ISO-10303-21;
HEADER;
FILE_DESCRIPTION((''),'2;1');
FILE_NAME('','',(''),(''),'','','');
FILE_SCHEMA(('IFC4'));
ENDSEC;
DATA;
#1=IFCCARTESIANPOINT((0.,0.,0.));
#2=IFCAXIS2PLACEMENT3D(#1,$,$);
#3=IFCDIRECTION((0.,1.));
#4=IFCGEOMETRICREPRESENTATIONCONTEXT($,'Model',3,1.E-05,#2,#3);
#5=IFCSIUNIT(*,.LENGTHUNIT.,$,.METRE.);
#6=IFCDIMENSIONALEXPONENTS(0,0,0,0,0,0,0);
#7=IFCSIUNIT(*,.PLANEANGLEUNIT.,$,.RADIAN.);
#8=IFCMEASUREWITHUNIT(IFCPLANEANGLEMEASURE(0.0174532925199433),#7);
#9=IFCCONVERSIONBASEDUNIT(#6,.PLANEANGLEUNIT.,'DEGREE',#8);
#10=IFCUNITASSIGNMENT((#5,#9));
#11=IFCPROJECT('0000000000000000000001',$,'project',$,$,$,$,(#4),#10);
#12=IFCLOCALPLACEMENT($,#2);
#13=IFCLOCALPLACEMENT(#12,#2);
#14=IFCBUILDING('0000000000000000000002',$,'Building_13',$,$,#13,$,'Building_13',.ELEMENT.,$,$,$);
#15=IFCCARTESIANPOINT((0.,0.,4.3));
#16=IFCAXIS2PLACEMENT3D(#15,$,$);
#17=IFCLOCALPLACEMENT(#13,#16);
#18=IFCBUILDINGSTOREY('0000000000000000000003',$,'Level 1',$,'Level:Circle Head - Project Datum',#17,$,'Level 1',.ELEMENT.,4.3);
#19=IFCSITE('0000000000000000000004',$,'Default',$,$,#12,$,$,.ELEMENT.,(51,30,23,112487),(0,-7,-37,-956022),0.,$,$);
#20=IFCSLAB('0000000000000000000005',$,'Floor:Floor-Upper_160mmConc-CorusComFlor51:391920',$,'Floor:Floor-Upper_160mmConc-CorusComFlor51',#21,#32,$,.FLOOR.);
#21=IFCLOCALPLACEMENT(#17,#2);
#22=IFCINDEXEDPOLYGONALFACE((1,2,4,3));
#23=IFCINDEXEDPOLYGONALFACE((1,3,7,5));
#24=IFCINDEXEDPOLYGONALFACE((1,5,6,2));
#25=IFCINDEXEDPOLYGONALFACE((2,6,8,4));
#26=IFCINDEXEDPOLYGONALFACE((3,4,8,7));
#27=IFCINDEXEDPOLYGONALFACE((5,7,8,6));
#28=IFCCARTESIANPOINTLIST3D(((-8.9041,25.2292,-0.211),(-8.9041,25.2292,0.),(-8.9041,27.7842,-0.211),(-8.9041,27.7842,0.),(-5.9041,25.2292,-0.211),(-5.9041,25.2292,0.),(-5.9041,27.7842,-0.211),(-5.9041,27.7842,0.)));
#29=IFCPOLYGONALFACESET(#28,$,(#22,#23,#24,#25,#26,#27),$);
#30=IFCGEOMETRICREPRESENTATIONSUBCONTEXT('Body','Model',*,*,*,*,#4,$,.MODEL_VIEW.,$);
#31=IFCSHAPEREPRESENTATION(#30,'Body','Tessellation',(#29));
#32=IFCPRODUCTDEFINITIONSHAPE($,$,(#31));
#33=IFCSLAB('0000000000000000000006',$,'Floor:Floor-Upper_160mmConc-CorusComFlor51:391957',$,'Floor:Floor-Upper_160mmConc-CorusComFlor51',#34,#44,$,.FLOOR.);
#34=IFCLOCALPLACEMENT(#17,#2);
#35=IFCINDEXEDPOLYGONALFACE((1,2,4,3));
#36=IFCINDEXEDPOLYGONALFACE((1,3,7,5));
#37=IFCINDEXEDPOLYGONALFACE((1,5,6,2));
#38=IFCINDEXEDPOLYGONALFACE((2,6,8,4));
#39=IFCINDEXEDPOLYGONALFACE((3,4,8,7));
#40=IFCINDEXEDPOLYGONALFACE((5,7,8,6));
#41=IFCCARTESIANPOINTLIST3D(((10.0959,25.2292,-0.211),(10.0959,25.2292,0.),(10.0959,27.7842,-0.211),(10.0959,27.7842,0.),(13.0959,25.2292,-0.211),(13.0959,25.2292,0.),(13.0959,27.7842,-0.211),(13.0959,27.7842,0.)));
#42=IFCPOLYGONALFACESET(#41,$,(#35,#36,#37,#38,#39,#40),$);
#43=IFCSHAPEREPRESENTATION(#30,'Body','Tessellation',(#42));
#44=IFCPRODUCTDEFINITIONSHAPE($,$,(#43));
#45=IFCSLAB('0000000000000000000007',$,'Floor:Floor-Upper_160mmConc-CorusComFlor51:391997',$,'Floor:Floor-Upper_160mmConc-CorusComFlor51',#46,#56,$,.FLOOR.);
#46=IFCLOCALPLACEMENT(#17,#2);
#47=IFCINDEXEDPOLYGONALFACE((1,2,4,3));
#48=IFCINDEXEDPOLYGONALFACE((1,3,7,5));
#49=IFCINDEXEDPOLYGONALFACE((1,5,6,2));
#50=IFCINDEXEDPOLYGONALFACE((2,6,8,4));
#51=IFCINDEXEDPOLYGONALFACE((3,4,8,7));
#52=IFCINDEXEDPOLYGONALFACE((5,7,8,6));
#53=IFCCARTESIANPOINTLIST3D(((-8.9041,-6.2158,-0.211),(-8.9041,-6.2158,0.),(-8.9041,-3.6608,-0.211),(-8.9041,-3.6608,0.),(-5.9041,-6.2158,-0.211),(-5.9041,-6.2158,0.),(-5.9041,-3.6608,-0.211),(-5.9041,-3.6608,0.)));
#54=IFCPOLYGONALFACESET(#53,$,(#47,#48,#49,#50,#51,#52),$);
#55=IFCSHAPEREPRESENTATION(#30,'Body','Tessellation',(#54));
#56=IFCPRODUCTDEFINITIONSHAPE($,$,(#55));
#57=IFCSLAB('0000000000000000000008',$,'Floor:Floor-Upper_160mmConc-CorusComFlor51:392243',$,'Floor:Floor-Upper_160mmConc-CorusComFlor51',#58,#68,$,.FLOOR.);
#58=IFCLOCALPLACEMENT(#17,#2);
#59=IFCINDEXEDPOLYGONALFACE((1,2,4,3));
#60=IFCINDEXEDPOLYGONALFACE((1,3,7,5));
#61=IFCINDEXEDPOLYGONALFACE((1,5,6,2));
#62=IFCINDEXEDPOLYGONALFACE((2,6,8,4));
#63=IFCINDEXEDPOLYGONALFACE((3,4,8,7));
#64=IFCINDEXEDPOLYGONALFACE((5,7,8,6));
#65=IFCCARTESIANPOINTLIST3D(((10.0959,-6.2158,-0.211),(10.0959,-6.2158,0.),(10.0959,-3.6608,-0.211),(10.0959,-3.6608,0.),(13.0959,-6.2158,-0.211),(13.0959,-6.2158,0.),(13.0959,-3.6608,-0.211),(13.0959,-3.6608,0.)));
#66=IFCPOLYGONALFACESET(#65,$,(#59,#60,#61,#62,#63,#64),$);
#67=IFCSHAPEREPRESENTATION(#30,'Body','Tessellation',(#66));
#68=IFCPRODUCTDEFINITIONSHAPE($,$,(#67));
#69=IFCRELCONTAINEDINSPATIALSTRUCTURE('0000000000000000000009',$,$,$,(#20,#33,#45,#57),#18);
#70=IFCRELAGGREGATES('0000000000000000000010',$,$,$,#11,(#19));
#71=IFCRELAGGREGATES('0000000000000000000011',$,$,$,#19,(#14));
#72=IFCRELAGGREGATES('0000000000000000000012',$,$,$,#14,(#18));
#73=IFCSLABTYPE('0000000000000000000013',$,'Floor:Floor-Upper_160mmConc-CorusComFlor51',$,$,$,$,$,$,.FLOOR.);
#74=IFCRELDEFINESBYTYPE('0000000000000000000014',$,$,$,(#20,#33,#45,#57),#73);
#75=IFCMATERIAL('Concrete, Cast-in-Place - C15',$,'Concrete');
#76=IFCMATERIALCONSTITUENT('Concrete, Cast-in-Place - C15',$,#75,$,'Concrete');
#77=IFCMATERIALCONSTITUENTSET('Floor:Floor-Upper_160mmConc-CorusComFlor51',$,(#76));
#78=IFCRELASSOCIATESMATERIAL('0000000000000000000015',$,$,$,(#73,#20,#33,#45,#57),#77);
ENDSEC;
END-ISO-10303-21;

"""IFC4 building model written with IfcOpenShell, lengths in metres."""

from ifc_helpers import new_model, entity, si_unit, converted_unit, direction, frame, origin, place, context, subcontext, project, spatial, indexed_curve, outline, extrude, material, constituent, constituent_set, type_object, element, save


model = new_model("IFC4")

# Units and contexts
model_context = context("Model", 3, precision=1e-05, world=origin(), true_north=direction((0.0, 1.0)))
body_context = subcontext(model_context, "Body", "Model", "MODEL_VIEW")
ifc_project = project(units=[si_unit("LENGTHUNIT", "METRE"), converted_unit("PLANEANGLEUNIT", "DEGREE", entity("IfcPlaneAngleMeasure", 0.0174532925199433), si_unit("PLANEANGLEUNIT", "RADIAN"), dimensions=[0, 0, 0, 0, 0, 0, 0])], contexts=[model_context])

# Site, building, storey
site_placement = place(None, origin())
site = spatial("IfcSite", under=ifc_project, at=site_placement, Name="Default", CompositionType="ELEMENT", RefLatitude=(51, 30, 23, 112487), RefLongitude=(0, -7, -37, -956022), RefElevation=0.0)
building_placement = place(site_placement, origin())
building = spatial("IfcBuilding", under=site, at=building_placement, Name="Building_13", LongName="Building_13", CompositionType="ELEMENT")
storey_placement = place(building_placement, frame((0.0, 0.0, 4.3)))
storey = spatial("IfcBuildingStorey", under=building, at=storey_placement, Name="Level 1", ObjectType="Level:Circle Head - Project Datum", LongName="Level 1", CompositionType="ELEMENT", Elevation=4.3)

# Slabs
ifc_material_1 = material(Name="Concrete, Cast-in-Place - C15", Category="Concrete")
ifc_constituent_1 = constituent(ifc_material_1, Name="Concrete, Cast-in-Place - C15", Category="Concrete")
ifc_constituent_set_1 = constituent_set(constituents=[ifc_constituent_1], Name="Floor:Floor-Upper_160mmConc-CorusComFlor51")
slab_type_1 = type_object("IfcSlabType", Name="Floor:Floor-Upper_160mmConc-CorusComFlor51", PredefinedType="FLOOR", material=ifc_constituent_set_1)
slab_1_placement = place(storey_placement, origin())
element("IfcSlab", 1, at=slab_1_placement, inside=storey, type_object=slab_type_1, material=ifc_constituent_set_1, Name="Floor:Floor-Upper_160mmConc-CorusComFlor51:391920", ObjectType="Floor:Floor-Upper_160mmConc-CorusComFlor51", PredefinedType="FLOOR", context=body_context, shape_type="SweptSolid", body=[
    extrude(outline(indexed_curve([(-1.2775, -1.5), (1.2775, -1.5), (1.2775, 1.5), (-1.2775, 1.5), (-1.2775, -1.5)], self_intersect=False)), frame((-7.4041, 26.5067, 0.0), z_axis=(0.0, 0.0, -1.0), x_axis=(0.0, 1.0, 0.0)), (0.0, 0.0, 1.0), 0.211),
])
slab_2_placement = place(storey_placement, origin())
element("IfcSlab", 2, at=slab_2_placement, inside=storey, type_object=slab_type_1, material=ifc_constituent_set_1, Name="Floor:Floor-Upper_160mmConc-CorusComFlor51:391957", ObjectType="Floor:Floor-Upper_160mmConc-CorusComFlor51", PredefinedType="FLOOR", context=body_context, shape_type="SweptSolid", body=[
    extrude(outline(indexed_curve([(-1.2775, -1.5), (1.2775, -1.5), (1.2775, 1.5), (-1.2775, 1.5), (-1.2775, -1.5)], self_intersect=False)), frame((11.5959, 26.5067, 0.0), z_axis=(0.0, 0.0, -1.0), x_axis=(0.0, 1.0, 0.0)), (0.0, 0.0, 1.0), 0.211),
])
slab_3_placement = place(storey_placement, origin())
element("IfcSlab", 3, at=slab_3_placement, inside=storey, type_object=slab_type_1, material=ifc_constituent_set_1, Name="Floor:Floor-Upper_160mmConc-CorusComFlor51:391997", ObjectType="Floor:Floor-Upper_160mmConc-CorusComFlor51", PredefinedType="FLOOR", context=body_context, shape_type="SweptSolid", body=[
    extrude(outline(indexed_curve([(-1.2775, -1.5), (1.2775, -1.5), (1.2775, 1.5), (-1.2775, 1.5), (-1.2775, -1.5)], self_intersect=False)), frame((-7.4041, -4.9383, 0.0), z_axis=(0.0, 0.0, -1.0), x_axis=(0.0, 1.0, 0.0)), (0.0, 0.0, 1.0), 0.211),
])
slab_4_placement = place(storey_placement, origin())
element("IfcSlab", 4, at=slab_4_placement, inside=storey, type_object=slab_type_1, material=ifc_constituent_set_1, Name="Floor:Floor-Upper_160mmConc-CorusComFlor51:392243", ObjectType="Floor:Floor-Upper_160mmConc-CorusComFlor51", PredefinedType="FLOOR", context=body_context, shape_type="SweptSolid", body=[
    extrude(outline(indexed_curve([(-1.2775, -1.5), (1.2775, -1.5), (1.2775, 1.5), (-1.2775, 1.5), (-1.2775, -1.5)], self_intersect=False)), frame((11.5959, -4.9383, 0.0), z_axis=(0.0, 0.0, -1.0), x_axis=(0.0, 1.0, 0.0)), (0.0, 0.0, 1.0), 0.211),
])

save(model, "model.ifc")
